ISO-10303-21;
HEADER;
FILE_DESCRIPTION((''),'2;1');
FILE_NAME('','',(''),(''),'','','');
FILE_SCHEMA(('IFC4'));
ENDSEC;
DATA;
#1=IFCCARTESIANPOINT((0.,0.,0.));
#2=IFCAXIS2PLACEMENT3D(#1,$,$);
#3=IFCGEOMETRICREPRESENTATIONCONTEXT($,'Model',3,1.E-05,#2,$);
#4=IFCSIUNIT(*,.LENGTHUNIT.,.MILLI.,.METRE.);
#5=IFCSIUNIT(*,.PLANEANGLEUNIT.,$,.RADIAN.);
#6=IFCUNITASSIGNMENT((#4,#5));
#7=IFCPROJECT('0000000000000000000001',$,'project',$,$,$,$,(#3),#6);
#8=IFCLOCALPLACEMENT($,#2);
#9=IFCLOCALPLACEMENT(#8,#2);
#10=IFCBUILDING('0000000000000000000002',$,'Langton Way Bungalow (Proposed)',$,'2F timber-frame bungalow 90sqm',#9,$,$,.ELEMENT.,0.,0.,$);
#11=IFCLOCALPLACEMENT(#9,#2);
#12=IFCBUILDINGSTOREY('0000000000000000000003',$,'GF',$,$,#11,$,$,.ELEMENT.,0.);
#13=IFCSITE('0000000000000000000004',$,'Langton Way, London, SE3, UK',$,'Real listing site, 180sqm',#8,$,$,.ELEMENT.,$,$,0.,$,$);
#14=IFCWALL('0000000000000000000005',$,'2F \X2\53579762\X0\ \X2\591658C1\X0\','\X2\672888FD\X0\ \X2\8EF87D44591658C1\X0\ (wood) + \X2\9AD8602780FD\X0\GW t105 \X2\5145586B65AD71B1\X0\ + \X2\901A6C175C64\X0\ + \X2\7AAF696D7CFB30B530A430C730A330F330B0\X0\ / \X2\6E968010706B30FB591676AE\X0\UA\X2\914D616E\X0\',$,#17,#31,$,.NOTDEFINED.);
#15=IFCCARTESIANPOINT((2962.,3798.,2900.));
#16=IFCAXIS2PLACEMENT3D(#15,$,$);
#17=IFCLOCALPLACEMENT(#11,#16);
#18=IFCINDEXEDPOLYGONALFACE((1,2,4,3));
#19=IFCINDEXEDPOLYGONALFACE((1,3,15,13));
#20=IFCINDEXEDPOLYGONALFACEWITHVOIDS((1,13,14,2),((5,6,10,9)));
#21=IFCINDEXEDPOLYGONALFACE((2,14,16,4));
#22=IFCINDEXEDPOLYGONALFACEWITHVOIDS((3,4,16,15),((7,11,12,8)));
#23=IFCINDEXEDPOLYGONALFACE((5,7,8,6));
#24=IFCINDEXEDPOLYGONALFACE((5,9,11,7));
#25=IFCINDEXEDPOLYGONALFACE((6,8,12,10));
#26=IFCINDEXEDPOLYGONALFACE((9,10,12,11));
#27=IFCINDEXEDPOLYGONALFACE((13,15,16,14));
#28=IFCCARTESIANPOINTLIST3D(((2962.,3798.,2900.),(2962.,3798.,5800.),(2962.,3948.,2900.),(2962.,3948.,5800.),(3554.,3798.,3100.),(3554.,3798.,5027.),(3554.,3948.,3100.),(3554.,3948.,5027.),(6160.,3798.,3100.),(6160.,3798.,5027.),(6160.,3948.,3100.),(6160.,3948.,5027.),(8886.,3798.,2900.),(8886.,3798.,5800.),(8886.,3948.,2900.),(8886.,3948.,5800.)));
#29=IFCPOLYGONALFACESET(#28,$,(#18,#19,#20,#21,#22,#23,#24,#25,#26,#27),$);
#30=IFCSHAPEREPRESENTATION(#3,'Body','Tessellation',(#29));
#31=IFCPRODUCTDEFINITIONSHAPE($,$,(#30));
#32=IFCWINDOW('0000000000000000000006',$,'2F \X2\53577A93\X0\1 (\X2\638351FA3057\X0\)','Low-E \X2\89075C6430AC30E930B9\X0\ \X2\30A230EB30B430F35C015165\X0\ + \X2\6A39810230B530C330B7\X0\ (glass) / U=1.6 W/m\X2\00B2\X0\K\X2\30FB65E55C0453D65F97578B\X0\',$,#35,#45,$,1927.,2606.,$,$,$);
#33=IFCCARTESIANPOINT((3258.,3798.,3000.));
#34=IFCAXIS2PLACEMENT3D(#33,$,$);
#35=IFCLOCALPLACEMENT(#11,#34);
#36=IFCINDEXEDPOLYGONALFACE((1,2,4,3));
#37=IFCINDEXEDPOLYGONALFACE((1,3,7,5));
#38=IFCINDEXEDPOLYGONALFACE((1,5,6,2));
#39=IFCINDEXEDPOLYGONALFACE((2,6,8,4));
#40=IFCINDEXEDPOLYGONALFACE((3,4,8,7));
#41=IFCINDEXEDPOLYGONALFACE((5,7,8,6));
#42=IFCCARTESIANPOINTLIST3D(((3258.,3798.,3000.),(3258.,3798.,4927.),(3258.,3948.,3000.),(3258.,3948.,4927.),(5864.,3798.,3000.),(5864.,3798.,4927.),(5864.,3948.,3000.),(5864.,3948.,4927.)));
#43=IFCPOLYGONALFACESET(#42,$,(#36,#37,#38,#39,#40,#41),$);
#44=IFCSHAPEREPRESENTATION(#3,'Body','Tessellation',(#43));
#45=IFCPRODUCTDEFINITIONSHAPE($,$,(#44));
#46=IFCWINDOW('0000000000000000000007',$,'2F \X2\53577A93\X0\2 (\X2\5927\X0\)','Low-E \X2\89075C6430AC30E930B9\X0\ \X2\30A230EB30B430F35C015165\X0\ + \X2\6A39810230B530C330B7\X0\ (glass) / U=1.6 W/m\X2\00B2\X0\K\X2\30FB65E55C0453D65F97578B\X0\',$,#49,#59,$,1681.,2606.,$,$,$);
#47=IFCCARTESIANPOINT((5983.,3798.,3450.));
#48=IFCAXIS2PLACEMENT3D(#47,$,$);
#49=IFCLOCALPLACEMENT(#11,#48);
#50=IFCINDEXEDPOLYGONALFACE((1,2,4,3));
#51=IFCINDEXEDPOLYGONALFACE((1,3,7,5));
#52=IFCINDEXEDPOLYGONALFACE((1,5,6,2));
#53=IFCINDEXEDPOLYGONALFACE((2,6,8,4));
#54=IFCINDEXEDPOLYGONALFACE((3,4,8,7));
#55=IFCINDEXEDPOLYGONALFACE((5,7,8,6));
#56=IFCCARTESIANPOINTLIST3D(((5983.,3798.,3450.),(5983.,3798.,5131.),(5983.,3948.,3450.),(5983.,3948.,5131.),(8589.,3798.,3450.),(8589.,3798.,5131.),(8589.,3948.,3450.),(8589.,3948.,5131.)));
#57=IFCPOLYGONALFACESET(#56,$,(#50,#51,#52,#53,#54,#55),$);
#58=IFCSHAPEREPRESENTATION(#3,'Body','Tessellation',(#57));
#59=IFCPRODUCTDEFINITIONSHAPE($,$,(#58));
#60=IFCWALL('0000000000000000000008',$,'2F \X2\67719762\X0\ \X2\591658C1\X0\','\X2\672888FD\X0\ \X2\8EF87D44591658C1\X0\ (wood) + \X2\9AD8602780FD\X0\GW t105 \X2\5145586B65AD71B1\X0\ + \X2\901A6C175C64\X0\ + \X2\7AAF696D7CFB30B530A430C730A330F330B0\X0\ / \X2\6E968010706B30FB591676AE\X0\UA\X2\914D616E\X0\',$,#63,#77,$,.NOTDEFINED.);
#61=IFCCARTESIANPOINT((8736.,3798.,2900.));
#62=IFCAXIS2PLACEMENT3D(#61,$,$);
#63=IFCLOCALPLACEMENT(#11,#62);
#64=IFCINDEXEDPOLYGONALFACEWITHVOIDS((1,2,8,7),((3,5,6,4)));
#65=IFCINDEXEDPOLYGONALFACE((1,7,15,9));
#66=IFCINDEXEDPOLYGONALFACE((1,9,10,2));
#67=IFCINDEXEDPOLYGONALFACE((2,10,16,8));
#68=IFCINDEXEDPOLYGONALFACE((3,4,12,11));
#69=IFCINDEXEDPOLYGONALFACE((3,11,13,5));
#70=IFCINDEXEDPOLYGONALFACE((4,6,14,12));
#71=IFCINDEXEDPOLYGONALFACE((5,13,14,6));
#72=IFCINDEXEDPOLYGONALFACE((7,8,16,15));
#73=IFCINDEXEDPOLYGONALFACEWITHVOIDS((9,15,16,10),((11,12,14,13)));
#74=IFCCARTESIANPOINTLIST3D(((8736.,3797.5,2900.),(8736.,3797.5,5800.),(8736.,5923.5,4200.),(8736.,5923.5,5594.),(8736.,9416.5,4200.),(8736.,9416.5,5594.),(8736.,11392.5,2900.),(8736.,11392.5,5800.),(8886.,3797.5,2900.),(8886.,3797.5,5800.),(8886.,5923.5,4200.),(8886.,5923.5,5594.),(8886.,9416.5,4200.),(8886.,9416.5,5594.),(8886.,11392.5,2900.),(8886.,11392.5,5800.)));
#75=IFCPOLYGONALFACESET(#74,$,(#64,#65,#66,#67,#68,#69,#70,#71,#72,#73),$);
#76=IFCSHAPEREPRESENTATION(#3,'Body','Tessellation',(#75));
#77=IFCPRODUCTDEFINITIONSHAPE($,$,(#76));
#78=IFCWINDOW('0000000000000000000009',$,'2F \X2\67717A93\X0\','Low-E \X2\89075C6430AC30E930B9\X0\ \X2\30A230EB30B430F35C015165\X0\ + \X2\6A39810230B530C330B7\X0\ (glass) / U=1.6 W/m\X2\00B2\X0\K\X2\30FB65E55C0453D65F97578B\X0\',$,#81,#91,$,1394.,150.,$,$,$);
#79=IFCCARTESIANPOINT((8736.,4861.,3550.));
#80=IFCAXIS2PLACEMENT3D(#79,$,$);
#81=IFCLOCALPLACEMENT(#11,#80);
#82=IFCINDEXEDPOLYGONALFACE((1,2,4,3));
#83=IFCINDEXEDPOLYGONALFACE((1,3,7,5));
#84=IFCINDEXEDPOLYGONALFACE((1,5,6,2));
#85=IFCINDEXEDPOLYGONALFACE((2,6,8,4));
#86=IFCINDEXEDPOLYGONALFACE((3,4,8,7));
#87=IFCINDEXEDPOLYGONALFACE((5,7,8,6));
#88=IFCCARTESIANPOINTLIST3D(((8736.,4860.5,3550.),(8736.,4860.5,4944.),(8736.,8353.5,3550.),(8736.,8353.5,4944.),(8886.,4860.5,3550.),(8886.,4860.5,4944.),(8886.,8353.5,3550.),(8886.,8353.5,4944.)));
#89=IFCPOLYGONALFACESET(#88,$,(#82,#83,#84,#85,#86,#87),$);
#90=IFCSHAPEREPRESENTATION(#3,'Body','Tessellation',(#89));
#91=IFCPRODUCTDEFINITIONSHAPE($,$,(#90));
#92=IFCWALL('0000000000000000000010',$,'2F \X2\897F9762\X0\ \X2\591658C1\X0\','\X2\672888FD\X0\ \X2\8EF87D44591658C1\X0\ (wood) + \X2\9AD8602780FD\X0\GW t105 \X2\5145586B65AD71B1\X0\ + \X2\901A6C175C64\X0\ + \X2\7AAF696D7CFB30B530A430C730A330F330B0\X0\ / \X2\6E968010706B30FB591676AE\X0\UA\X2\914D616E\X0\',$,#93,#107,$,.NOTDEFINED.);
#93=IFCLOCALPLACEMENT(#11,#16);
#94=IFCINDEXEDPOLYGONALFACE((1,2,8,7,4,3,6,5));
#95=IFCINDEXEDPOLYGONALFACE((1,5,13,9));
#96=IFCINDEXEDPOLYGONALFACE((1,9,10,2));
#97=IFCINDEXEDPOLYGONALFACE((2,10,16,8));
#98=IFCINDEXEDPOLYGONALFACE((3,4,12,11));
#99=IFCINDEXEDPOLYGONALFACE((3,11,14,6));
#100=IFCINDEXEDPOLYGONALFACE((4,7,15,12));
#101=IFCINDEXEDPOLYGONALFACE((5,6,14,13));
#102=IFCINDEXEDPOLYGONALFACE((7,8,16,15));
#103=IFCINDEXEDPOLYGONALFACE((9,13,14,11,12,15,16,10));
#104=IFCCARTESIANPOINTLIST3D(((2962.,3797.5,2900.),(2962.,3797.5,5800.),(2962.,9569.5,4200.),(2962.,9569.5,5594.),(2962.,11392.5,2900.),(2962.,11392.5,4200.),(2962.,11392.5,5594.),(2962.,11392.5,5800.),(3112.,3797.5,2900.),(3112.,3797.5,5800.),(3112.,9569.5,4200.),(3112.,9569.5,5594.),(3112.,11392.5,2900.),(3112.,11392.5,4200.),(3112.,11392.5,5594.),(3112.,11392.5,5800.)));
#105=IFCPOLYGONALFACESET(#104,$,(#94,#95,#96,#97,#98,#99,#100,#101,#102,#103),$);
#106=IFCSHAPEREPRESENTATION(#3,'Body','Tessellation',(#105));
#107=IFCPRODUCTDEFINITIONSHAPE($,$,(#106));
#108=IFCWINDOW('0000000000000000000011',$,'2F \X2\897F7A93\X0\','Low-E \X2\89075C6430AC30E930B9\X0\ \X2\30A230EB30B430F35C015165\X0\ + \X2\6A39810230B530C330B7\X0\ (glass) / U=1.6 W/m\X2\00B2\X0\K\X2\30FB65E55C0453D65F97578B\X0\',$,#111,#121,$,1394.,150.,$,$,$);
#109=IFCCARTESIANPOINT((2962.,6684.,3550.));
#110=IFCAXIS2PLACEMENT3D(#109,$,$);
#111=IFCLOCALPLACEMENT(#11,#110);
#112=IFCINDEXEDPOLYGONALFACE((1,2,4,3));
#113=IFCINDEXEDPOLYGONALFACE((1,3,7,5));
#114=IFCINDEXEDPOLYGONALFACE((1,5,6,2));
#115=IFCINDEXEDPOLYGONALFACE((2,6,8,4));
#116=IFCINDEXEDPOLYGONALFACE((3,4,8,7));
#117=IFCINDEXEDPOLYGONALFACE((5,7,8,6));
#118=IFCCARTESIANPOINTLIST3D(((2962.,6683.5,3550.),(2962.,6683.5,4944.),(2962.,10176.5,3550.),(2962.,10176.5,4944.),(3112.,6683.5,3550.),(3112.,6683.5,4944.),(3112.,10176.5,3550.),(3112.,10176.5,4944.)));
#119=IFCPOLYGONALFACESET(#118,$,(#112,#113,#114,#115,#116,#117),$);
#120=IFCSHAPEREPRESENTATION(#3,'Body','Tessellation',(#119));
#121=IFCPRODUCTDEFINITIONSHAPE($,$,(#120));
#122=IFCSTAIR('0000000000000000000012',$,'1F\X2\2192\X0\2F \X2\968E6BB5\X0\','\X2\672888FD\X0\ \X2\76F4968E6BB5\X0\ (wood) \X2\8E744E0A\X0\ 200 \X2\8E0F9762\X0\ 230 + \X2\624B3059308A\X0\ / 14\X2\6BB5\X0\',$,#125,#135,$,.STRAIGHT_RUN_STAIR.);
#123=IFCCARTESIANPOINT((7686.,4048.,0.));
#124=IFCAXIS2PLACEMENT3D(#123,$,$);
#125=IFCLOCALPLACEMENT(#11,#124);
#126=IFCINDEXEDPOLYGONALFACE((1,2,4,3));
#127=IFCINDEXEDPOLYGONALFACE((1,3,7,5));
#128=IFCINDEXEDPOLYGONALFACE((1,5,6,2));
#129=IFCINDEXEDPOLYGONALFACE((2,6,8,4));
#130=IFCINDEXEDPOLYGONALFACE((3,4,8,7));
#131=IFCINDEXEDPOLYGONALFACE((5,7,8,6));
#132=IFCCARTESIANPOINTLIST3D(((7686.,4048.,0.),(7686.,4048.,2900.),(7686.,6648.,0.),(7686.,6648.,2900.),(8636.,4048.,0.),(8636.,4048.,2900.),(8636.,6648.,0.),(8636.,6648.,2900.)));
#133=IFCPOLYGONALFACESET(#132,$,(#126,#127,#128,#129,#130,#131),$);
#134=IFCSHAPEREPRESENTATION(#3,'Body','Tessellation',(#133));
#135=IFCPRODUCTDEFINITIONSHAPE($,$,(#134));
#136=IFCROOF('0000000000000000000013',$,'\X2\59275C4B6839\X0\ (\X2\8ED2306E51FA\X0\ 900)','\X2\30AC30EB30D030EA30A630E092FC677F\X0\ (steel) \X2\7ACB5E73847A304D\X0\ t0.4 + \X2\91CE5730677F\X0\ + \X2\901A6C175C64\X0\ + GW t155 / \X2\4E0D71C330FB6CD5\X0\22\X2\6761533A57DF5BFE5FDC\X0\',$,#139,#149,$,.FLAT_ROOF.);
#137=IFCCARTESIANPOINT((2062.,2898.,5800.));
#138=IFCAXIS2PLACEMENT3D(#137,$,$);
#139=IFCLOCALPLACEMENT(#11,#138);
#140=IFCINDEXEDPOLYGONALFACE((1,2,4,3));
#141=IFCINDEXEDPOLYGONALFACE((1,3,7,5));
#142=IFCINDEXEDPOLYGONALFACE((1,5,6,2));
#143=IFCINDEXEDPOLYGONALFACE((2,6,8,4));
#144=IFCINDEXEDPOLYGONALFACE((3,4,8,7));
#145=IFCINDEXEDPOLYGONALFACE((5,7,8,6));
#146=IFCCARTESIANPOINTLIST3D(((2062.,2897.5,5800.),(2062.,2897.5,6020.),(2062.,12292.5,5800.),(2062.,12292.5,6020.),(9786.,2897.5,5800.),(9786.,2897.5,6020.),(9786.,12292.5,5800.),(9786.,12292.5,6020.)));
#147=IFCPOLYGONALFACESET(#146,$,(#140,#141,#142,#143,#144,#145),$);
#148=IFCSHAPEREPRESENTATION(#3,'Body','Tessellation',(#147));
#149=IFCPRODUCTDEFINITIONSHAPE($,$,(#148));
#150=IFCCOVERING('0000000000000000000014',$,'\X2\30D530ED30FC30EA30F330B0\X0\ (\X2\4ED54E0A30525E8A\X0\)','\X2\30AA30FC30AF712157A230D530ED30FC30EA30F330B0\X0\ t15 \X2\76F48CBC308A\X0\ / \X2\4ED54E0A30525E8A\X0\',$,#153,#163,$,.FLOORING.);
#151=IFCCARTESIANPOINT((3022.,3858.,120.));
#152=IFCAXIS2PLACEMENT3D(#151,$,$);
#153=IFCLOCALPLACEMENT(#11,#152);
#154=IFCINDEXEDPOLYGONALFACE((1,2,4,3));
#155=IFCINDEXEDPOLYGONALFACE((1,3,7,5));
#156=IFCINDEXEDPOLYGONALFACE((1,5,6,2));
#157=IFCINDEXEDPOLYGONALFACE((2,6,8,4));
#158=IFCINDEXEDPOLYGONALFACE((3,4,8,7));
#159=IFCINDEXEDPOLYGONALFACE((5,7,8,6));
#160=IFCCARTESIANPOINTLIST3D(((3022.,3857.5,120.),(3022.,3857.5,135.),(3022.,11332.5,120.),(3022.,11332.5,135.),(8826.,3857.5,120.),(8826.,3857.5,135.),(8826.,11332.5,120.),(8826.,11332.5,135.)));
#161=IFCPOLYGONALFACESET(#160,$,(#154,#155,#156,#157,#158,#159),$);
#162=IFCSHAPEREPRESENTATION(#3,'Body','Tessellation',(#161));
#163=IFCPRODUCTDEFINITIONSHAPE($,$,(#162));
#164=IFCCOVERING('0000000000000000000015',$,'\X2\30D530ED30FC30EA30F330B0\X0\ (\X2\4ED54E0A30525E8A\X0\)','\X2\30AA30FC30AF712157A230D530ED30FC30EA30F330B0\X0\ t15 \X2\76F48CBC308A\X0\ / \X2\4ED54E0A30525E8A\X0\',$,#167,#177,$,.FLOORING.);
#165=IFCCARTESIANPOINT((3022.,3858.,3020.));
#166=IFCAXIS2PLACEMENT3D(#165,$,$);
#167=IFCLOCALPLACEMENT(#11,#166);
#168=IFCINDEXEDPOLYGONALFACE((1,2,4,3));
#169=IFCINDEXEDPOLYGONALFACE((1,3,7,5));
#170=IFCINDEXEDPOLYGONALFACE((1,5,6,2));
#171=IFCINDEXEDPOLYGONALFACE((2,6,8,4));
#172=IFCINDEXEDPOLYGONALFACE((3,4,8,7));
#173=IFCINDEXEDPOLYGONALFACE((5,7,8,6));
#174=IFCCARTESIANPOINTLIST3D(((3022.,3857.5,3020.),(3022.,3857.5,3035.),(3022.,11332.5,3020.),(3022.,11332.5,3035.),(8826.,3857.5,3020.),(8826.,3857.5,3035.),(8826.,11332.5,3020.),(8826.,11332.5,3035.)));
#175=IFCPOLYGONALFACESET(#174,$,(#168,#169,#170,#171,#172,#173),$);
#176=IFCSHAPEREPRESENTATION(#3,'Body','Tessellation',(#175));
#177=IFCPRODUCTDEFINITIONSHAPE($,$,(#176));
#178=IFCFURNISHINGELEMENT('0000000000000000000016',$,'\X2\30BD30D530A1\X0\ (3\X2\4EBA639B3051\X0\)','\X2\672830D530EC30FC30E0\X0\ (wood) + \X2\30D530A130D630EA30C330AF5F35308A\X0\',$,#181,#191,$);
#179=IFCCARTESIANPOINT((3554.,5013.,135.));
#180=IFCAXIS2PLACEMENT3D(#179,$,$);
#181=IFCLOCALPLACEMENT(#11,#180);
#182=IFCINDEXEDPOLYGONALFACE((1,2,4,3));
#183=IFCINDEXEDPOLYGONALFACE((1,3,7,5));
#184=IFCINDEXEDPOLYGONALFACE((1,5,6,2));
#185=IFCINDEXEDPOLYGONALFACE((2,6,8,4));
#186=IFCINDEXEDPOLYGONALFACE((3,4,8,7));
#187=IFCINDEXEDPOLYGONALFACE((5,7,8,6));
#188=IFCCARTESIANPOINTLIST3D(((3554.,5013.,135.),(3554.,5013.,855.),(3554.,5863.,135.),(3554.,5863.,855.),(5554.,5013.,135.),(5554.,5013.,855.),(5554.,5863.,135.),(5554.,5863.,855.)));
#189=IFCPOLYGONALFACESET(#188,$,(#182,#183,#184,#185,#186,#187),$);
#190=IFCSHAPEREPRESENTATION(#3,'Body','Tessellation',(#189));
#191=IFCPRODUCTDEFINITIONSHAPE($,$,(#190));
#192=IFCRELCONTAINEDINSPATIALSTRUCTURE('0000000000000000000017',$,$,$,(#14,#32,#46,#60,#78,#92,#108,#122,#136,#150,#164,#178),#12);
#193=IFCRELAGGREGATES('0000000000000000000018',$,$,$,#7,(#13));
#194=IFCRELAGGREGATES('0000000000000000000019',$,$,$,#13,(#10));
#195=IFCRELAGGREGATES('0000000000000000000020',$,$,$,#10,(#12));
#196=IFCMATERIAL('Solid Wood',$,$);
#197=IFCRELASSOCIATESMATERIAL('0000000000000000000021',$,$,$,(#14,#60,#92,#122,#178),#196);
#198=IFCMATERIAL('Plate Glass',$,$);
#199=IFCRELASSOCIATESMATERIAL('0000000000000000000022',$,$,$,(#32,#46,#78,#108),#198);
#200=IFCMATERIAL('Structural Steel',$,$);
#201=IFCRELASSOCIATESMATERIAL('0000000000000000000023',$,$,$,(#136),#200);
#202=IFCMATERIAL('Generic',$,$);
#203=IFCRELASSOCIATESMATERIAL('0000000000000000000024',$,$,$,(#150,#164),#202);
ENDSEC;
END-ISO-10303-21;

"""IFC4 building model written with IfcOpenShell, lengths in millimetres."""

from ifc_helpers import new_model, si_unit, frame, frame_2d, origin, place, context, project, spatial, rectangle, extrude, material, element, fill, save


model = new_model("IFC4")

# Units and contexts
model_context = context("Model", 3, precision=1e-05, world=origin())
ifc_project = project(units=[si_unit("LENGTHUNIT", "METRE", prefix="MILLI"), si_unit("PLANEANGLEUNIT", "RADIAN")], contexts=[model_context])

# Site, building, storey
site_placement = place(None, origin())
site = spatial("IfcSite", under=ifc_project, at=site_placement, Name="Langton Way, London, SE3, UK", ObjectType="Real listing site, 180sqm", CompositionType="ELEMENT", RefElevation=0.0)
building_placement = place(site_placement, origin())
building = spatial("IfcBuilding", under=site, at=building_placement, Name="Langton Way Bungalow (Proposed)", ObjectType="2F timber-frame bungalow 90sqm", CompositionType="ELEMENT", ElevationOfRefHeight=0.0, ElevationOfTerrain=0.0)
storey_placement = place(building_placement, origin())
storey = spatial("IfcBuildingStorey", under=building, at=storey_placement, Name="GF", CompositionType="ELEMENT", Elevation=0.0)

# Shared definitions
ifc_material_1 = material(Name="Solid Wood")

# Shared definitions
ifc_material_2 = material(Name="Plate Glass")

# Wall, openings, windows
wall_1_placement = place(storey_placement, frame((2962.0, 3798.0, 2900.0)))
wall_1 = element("IfcWall", 1, at=wall_1_placement, inside=storey, material=ifc_material_1, Name="2F 南面 外壁", Description="木製 軸組外壁 (wood) + 高性能GW t105 充填断熱 + 通気層 + 窯業系サイディング / 準耐火・外皮UA配慮", PredefinedType="NOTDEFINED", context=model_context, shape_type="SweptSolid", body=[
    extrude(rectangle(XDim=5924.0, YDim=150.0, at=frame_2d((2962.0, 75.0))), frame((2962.0, 3798.0, 2900.0)), (0.0, 0.0, 1.0), 2900.0),
])
opening_1_placement = place(storey_placement, frame((3258.0, 3798.0, 3000.0)))
opening_1 = element("IfcOpeningElement", 2, at=opening_1_placement, cuts=wall_1, PredefinedType="NOTDEFINED", context=model_context, shape_type="SweptSolid", body=[
    extrude(rectangle(XDim=2606.0, YDim=150.0, at=frame_2d((1303.0, 75.0))), frame((3258.0, 3798.0, 3000.0)), (0.0, 0.0, 1.0), 1927.0),
])
opening_2_placement = place(storey_placement, frame((5983.0, 3798.0, 3450.0)))
opening_2 = element("IfcOpeningElement", 3, at=opening_2_placement, cuts=wall_1, PredefinedType="NOTDEFINED", context=model_context, shape_type="SweptSolid", body=[
    extrude(rectangle(XDim=2606.0, YDim=150.0, at=frame_2d((1303.0, 75.0))), frame((5983.0, 3798.0, 3450.0)), (0.0, 0.0, 1.0), 1681.0),
])
window_1_placement = place(storey_placement, frame((3258.0, 3798.0, 3000.0)))
window_1 = element("IfcWindow", 4, at=window_1_placement, inside=storey, material=ifc_material_2, Name="2F 南窓1 (掃出し)", Description="Low-E 複層ガラス アルゴン封入 + 樹脂サッシ (glass) / U=1.6 W/m²K・日射取得型", OverallHeight=1927.0, OverallWidth=2606.0, context=model_context, shape_type="SweptSolid", body=[
    extrude(rectangle(XDim=2606.0, YDim=150.0, at=frame_2d((1303.0, 75.0))), frame((3258.0, 3798.0, 3000.0)), (0.0, 0.0, 1.0), 1927.0),
])
fill(opening_1, window_1)
window_2_placement = place(storey_placement, frame((5983.0, 3798.0, 3450.0)))
window_2 = element("IfcWindow", 5, at=window_2_placement, inside=storey, material=ifc_material_2, Name="2F 南窓2 (大)", Description="Low-E 複層ガラス アルゴン封入 + 樹脂サッシ (glass) / U=1.6 W/m²K・日射取得型", OverallHeight=1681.0, OverallWidth=2606.0, context=model_context, shape_type="SweptSolid", body=[
    extrude(rectangle(XDim=2606.0, YDim=150.0, at=frame_2d((1303.0, 75.0))), frame((5983.0, 3798.0, 3450.0)), (0.0, 0.0, 1.0), 1681.0),
])
fill(opening_2, window_2)

# Walls, openings, windows
wall_2_placement = place(storey_placement, frame((8736.0, 3798.0, 2900.0)))
wall_2 = element("IfcWall", 6, at=wall_2_placement, inside=storey, material=ifc_material_1, Name="2F 東面 外壁", Description="木製 軸組外壁 (wood) + 高性能GW t105 充填断熱 + 通気層 + 窯業系サイディング / 準耐火・外皮UA配慮", PredefinedType="NOTDEFINED", context=model_context, shape_type="SweptSolid", body=[
    extrude(rectangle(XDim=150.0, YDim=7595.0, at=frame_2d((75.0, 3797.0))), frame((8736.0, 3798.0, 2900.0)), (0.0, 0.0, 1.0), 2900.0),
])
opening_3_placement = place(storey_placement, frame((8736.0, 4861.0, 3550.0)))
opening_3 = element("IfcOpeningElement", 7, at=opening_3_placement, cuts=wall_2, PredefinedType="NOTDEFINED", context=model_context, shape_type="SweptSolid", body=[
    extrude(rectangle(XDim=150.0, YDim=3493.0, at=frame_2d((75.0, 1746.0))), frame((8736.0, 4861.0, 3550.0)), (0.0, 0.0, 1.0), 1394.0),
])
window_3_placement = place(storey_placement, frame((8736.0, 4861.0, 3550.0)))
window_3 = element("IfcWindow", 8, at=window_3_placement, inside=storey, material=ifc_material_2, Name="2F 東窓", Description="Low-E 複層ガラス アルゴン封入 + 樹脂サッシ (glass) / U=1.6 W/m²K・日射取得型", OverallHeight=1394.0, OverallWidth=150.0, context=model_context, shape_type="SweptSolid", body=[
    extrude(rectangle(XDim=150.0, YDim=3493.0, at=frame_2d((75.0, 1746.0))), frame((8736.0, 4861.0, 3550.0)), (0.0, 0.0, 1.0), 1394.0),
])
fill(opening_3, window_3)
wall_3_placement = place(storey_placement, frame((2962.0, 3798.0, 2900.0)))
wall_3 = element("IfcWall", 9, at=wall_3_placement, inside=storey, material=ifc_material_1, Name="2F 西面 外壁", Description="木製 軸組外壁 (wood) + 高性能GW t105 充填断熱 + 通気層 + 窯業系サイディング / 準耐火・外皮UA配慮", PredefinedType="NOTDEFINED", context=model_context, shape_type="SweptSolid", body=[
    extrude(rectangle(XDim=150.0, YDim=7595.0, at=frame_2d((75.0, 3797.0))), frame((2962.0, 3798.0, 2900.0)), (0.0, 0.0, 1.0), 2900.0),
])
opening_4_placement = place(storey_placement, frame((2962.0, 6684.0, 3550.0)))
opening_4 = element("IfcOpeningElement", 10, at=opening_4_placement, cuts=wall_3, PredefinedType="NOTDEFINED", context=model_context, shape_type="SweptSolid", body=[
    extrude(rectangle(XDim=150.0, YDim=3493.0, at=frame_2d((75.0, 1746.0))), frame((2962.0, 6684.0, 3550.0)), (0.0, 0.0, 1.0), 1394.0),
])
window_4_placement = place(storey_placement, frame((2962.0, 6684.0, 3550.0)))
window_4 = element("IfcWindow", 11, at=window_4_placement, inside=storey, material=ifc_material_2, Name="2F 西窓", Description="Low-E 複層ガラス アルゴン封入 + 樹脂サッシ (glass) / U=1.6 W/m²K・日射取得型", OverallHeight=1394.0, OverallWidth=150.0, context=model_context, shape_type="SweptSolid", body=[
    extrude(rectangle(XDim=150.0, YDim=3493.0, at=frame_2d((75.0, 1746.0))), frame((2962.0, 6684.0, 3550.0)), (0.0, 0.0, 1.0), 1394.0),
])
fill(opening_4, window_4)

# Stair
stair_placement = place(storey_placement, frame((7686.0, 4048.0, 0.0)))
element("IfcStair", 12, at=stair_placement, inside=storey, material=ifc_material_1, Name="1F→2F 階段", Description="木製 直階段 (wood) 蹴上 200 踏面 230 + 手すり / 14段", PredefinedType="STRAIGHT_RUN_STAIR", context=model_context, shape_type="SweptSolid", body=[
    extrude(rectangle(XDim=950.0, YDim=2600.0, at=frame_2d((475.0, 1300.0))), frame((7686.0, 4048.0, 0.0)), (0.0, 0.0, 1.0), 2900.0),
])

# Roof
ifc_material_3 = material(Name="Structural Steel")
roof_placement = place(storey_placement, frame((2062.0, 2898.0, 5800.0)))
element("IfcRoof", 13, at=roof_placement, inside=storey, material=ifc_material_3, Name="大屋根 (軒の出 900)", Description="ガルバリウム鋼板 (steel) 立平葺き t0.4 + 野地板 + 通気層 + GW t155 / 不燃・法22条区域対応", PredefinedType="FLAT_ROOF", context=model_context, shape_type="SweptSolid", body=[
    extrude(rectangle(XDim=7724.0, YDim=9395.0, at=frame_2d((3862.0, 4697.0))), frame((2062.0, 2898.0, 5800.0)), (0.0, 0.0, 1.0), 220.0),
])

# Coverings
ifc_material_4 = material(Name="Generic")
covering_1_placement = place(storey_placement, frame((3022.0, 3858.0, 120.0)))
element("IfcCovering", 14, at=covering_1_placement, inside=storey, material=ifc_material_4, Name="フローリング (仕上げ床)", Description="オーク無垢フローリング t15 直貼り / 仕上げ床", PredefinedType="FLOORING", context=model_context, shape_type="SweptSolid", body=[
    extrude(rectangle(XDim=5804.0, YDim=7475.0, at=frame_2d((2902.0, 3737.0))), frame((3022.0, 3858.0, 120.0)), (0.0, 0.0, 1.0), 15.0),
])
covering_2_placement = place(storey_placement, frame((3022.0, 3858.0, 3020.0)))
element("IfcCovering", 15, at=covering_2_placement, inside=storey, material=ifc_material_4, Name="フローリング (仕上げ床)", Description="オーク無垢フローリング t15 直貼り / 仕上げ床", PredefinedType="FLOORING", context=model_context, shape_type="SweptSolid", body=[
    extrude(rectangle(XDim=5804.0, YDim=7475.0, at=frame_2d((2902.0, 3737.0))), frame((3022.0, 3858.0, 3020.0)), (0.0, 0.0, 1.0), 15.0),
])

# Furnishing element
furnishing_1_placement = place(storey_placement, frame((3554.0, 5013.0, 135.0)))
element("IfcFurnishingElement", 16, at=furnishing_1_placement, inside=storey, material=ifc_material_1, Name="ソファ (3人掛け)", Description="木フレーム (wood) + ファブリック張り", context=model_context, shape_type="SweptSolid", body=[
    extrude(rectangle(XDim=2000.0, YDim=850.0, at=frame_2d((1000.0, 425.0))), frame((3554.0, 5013.0, 135.0)), (0.0, 0.0, 1.0), 720.0),
])

save(model, "model.ifc")
